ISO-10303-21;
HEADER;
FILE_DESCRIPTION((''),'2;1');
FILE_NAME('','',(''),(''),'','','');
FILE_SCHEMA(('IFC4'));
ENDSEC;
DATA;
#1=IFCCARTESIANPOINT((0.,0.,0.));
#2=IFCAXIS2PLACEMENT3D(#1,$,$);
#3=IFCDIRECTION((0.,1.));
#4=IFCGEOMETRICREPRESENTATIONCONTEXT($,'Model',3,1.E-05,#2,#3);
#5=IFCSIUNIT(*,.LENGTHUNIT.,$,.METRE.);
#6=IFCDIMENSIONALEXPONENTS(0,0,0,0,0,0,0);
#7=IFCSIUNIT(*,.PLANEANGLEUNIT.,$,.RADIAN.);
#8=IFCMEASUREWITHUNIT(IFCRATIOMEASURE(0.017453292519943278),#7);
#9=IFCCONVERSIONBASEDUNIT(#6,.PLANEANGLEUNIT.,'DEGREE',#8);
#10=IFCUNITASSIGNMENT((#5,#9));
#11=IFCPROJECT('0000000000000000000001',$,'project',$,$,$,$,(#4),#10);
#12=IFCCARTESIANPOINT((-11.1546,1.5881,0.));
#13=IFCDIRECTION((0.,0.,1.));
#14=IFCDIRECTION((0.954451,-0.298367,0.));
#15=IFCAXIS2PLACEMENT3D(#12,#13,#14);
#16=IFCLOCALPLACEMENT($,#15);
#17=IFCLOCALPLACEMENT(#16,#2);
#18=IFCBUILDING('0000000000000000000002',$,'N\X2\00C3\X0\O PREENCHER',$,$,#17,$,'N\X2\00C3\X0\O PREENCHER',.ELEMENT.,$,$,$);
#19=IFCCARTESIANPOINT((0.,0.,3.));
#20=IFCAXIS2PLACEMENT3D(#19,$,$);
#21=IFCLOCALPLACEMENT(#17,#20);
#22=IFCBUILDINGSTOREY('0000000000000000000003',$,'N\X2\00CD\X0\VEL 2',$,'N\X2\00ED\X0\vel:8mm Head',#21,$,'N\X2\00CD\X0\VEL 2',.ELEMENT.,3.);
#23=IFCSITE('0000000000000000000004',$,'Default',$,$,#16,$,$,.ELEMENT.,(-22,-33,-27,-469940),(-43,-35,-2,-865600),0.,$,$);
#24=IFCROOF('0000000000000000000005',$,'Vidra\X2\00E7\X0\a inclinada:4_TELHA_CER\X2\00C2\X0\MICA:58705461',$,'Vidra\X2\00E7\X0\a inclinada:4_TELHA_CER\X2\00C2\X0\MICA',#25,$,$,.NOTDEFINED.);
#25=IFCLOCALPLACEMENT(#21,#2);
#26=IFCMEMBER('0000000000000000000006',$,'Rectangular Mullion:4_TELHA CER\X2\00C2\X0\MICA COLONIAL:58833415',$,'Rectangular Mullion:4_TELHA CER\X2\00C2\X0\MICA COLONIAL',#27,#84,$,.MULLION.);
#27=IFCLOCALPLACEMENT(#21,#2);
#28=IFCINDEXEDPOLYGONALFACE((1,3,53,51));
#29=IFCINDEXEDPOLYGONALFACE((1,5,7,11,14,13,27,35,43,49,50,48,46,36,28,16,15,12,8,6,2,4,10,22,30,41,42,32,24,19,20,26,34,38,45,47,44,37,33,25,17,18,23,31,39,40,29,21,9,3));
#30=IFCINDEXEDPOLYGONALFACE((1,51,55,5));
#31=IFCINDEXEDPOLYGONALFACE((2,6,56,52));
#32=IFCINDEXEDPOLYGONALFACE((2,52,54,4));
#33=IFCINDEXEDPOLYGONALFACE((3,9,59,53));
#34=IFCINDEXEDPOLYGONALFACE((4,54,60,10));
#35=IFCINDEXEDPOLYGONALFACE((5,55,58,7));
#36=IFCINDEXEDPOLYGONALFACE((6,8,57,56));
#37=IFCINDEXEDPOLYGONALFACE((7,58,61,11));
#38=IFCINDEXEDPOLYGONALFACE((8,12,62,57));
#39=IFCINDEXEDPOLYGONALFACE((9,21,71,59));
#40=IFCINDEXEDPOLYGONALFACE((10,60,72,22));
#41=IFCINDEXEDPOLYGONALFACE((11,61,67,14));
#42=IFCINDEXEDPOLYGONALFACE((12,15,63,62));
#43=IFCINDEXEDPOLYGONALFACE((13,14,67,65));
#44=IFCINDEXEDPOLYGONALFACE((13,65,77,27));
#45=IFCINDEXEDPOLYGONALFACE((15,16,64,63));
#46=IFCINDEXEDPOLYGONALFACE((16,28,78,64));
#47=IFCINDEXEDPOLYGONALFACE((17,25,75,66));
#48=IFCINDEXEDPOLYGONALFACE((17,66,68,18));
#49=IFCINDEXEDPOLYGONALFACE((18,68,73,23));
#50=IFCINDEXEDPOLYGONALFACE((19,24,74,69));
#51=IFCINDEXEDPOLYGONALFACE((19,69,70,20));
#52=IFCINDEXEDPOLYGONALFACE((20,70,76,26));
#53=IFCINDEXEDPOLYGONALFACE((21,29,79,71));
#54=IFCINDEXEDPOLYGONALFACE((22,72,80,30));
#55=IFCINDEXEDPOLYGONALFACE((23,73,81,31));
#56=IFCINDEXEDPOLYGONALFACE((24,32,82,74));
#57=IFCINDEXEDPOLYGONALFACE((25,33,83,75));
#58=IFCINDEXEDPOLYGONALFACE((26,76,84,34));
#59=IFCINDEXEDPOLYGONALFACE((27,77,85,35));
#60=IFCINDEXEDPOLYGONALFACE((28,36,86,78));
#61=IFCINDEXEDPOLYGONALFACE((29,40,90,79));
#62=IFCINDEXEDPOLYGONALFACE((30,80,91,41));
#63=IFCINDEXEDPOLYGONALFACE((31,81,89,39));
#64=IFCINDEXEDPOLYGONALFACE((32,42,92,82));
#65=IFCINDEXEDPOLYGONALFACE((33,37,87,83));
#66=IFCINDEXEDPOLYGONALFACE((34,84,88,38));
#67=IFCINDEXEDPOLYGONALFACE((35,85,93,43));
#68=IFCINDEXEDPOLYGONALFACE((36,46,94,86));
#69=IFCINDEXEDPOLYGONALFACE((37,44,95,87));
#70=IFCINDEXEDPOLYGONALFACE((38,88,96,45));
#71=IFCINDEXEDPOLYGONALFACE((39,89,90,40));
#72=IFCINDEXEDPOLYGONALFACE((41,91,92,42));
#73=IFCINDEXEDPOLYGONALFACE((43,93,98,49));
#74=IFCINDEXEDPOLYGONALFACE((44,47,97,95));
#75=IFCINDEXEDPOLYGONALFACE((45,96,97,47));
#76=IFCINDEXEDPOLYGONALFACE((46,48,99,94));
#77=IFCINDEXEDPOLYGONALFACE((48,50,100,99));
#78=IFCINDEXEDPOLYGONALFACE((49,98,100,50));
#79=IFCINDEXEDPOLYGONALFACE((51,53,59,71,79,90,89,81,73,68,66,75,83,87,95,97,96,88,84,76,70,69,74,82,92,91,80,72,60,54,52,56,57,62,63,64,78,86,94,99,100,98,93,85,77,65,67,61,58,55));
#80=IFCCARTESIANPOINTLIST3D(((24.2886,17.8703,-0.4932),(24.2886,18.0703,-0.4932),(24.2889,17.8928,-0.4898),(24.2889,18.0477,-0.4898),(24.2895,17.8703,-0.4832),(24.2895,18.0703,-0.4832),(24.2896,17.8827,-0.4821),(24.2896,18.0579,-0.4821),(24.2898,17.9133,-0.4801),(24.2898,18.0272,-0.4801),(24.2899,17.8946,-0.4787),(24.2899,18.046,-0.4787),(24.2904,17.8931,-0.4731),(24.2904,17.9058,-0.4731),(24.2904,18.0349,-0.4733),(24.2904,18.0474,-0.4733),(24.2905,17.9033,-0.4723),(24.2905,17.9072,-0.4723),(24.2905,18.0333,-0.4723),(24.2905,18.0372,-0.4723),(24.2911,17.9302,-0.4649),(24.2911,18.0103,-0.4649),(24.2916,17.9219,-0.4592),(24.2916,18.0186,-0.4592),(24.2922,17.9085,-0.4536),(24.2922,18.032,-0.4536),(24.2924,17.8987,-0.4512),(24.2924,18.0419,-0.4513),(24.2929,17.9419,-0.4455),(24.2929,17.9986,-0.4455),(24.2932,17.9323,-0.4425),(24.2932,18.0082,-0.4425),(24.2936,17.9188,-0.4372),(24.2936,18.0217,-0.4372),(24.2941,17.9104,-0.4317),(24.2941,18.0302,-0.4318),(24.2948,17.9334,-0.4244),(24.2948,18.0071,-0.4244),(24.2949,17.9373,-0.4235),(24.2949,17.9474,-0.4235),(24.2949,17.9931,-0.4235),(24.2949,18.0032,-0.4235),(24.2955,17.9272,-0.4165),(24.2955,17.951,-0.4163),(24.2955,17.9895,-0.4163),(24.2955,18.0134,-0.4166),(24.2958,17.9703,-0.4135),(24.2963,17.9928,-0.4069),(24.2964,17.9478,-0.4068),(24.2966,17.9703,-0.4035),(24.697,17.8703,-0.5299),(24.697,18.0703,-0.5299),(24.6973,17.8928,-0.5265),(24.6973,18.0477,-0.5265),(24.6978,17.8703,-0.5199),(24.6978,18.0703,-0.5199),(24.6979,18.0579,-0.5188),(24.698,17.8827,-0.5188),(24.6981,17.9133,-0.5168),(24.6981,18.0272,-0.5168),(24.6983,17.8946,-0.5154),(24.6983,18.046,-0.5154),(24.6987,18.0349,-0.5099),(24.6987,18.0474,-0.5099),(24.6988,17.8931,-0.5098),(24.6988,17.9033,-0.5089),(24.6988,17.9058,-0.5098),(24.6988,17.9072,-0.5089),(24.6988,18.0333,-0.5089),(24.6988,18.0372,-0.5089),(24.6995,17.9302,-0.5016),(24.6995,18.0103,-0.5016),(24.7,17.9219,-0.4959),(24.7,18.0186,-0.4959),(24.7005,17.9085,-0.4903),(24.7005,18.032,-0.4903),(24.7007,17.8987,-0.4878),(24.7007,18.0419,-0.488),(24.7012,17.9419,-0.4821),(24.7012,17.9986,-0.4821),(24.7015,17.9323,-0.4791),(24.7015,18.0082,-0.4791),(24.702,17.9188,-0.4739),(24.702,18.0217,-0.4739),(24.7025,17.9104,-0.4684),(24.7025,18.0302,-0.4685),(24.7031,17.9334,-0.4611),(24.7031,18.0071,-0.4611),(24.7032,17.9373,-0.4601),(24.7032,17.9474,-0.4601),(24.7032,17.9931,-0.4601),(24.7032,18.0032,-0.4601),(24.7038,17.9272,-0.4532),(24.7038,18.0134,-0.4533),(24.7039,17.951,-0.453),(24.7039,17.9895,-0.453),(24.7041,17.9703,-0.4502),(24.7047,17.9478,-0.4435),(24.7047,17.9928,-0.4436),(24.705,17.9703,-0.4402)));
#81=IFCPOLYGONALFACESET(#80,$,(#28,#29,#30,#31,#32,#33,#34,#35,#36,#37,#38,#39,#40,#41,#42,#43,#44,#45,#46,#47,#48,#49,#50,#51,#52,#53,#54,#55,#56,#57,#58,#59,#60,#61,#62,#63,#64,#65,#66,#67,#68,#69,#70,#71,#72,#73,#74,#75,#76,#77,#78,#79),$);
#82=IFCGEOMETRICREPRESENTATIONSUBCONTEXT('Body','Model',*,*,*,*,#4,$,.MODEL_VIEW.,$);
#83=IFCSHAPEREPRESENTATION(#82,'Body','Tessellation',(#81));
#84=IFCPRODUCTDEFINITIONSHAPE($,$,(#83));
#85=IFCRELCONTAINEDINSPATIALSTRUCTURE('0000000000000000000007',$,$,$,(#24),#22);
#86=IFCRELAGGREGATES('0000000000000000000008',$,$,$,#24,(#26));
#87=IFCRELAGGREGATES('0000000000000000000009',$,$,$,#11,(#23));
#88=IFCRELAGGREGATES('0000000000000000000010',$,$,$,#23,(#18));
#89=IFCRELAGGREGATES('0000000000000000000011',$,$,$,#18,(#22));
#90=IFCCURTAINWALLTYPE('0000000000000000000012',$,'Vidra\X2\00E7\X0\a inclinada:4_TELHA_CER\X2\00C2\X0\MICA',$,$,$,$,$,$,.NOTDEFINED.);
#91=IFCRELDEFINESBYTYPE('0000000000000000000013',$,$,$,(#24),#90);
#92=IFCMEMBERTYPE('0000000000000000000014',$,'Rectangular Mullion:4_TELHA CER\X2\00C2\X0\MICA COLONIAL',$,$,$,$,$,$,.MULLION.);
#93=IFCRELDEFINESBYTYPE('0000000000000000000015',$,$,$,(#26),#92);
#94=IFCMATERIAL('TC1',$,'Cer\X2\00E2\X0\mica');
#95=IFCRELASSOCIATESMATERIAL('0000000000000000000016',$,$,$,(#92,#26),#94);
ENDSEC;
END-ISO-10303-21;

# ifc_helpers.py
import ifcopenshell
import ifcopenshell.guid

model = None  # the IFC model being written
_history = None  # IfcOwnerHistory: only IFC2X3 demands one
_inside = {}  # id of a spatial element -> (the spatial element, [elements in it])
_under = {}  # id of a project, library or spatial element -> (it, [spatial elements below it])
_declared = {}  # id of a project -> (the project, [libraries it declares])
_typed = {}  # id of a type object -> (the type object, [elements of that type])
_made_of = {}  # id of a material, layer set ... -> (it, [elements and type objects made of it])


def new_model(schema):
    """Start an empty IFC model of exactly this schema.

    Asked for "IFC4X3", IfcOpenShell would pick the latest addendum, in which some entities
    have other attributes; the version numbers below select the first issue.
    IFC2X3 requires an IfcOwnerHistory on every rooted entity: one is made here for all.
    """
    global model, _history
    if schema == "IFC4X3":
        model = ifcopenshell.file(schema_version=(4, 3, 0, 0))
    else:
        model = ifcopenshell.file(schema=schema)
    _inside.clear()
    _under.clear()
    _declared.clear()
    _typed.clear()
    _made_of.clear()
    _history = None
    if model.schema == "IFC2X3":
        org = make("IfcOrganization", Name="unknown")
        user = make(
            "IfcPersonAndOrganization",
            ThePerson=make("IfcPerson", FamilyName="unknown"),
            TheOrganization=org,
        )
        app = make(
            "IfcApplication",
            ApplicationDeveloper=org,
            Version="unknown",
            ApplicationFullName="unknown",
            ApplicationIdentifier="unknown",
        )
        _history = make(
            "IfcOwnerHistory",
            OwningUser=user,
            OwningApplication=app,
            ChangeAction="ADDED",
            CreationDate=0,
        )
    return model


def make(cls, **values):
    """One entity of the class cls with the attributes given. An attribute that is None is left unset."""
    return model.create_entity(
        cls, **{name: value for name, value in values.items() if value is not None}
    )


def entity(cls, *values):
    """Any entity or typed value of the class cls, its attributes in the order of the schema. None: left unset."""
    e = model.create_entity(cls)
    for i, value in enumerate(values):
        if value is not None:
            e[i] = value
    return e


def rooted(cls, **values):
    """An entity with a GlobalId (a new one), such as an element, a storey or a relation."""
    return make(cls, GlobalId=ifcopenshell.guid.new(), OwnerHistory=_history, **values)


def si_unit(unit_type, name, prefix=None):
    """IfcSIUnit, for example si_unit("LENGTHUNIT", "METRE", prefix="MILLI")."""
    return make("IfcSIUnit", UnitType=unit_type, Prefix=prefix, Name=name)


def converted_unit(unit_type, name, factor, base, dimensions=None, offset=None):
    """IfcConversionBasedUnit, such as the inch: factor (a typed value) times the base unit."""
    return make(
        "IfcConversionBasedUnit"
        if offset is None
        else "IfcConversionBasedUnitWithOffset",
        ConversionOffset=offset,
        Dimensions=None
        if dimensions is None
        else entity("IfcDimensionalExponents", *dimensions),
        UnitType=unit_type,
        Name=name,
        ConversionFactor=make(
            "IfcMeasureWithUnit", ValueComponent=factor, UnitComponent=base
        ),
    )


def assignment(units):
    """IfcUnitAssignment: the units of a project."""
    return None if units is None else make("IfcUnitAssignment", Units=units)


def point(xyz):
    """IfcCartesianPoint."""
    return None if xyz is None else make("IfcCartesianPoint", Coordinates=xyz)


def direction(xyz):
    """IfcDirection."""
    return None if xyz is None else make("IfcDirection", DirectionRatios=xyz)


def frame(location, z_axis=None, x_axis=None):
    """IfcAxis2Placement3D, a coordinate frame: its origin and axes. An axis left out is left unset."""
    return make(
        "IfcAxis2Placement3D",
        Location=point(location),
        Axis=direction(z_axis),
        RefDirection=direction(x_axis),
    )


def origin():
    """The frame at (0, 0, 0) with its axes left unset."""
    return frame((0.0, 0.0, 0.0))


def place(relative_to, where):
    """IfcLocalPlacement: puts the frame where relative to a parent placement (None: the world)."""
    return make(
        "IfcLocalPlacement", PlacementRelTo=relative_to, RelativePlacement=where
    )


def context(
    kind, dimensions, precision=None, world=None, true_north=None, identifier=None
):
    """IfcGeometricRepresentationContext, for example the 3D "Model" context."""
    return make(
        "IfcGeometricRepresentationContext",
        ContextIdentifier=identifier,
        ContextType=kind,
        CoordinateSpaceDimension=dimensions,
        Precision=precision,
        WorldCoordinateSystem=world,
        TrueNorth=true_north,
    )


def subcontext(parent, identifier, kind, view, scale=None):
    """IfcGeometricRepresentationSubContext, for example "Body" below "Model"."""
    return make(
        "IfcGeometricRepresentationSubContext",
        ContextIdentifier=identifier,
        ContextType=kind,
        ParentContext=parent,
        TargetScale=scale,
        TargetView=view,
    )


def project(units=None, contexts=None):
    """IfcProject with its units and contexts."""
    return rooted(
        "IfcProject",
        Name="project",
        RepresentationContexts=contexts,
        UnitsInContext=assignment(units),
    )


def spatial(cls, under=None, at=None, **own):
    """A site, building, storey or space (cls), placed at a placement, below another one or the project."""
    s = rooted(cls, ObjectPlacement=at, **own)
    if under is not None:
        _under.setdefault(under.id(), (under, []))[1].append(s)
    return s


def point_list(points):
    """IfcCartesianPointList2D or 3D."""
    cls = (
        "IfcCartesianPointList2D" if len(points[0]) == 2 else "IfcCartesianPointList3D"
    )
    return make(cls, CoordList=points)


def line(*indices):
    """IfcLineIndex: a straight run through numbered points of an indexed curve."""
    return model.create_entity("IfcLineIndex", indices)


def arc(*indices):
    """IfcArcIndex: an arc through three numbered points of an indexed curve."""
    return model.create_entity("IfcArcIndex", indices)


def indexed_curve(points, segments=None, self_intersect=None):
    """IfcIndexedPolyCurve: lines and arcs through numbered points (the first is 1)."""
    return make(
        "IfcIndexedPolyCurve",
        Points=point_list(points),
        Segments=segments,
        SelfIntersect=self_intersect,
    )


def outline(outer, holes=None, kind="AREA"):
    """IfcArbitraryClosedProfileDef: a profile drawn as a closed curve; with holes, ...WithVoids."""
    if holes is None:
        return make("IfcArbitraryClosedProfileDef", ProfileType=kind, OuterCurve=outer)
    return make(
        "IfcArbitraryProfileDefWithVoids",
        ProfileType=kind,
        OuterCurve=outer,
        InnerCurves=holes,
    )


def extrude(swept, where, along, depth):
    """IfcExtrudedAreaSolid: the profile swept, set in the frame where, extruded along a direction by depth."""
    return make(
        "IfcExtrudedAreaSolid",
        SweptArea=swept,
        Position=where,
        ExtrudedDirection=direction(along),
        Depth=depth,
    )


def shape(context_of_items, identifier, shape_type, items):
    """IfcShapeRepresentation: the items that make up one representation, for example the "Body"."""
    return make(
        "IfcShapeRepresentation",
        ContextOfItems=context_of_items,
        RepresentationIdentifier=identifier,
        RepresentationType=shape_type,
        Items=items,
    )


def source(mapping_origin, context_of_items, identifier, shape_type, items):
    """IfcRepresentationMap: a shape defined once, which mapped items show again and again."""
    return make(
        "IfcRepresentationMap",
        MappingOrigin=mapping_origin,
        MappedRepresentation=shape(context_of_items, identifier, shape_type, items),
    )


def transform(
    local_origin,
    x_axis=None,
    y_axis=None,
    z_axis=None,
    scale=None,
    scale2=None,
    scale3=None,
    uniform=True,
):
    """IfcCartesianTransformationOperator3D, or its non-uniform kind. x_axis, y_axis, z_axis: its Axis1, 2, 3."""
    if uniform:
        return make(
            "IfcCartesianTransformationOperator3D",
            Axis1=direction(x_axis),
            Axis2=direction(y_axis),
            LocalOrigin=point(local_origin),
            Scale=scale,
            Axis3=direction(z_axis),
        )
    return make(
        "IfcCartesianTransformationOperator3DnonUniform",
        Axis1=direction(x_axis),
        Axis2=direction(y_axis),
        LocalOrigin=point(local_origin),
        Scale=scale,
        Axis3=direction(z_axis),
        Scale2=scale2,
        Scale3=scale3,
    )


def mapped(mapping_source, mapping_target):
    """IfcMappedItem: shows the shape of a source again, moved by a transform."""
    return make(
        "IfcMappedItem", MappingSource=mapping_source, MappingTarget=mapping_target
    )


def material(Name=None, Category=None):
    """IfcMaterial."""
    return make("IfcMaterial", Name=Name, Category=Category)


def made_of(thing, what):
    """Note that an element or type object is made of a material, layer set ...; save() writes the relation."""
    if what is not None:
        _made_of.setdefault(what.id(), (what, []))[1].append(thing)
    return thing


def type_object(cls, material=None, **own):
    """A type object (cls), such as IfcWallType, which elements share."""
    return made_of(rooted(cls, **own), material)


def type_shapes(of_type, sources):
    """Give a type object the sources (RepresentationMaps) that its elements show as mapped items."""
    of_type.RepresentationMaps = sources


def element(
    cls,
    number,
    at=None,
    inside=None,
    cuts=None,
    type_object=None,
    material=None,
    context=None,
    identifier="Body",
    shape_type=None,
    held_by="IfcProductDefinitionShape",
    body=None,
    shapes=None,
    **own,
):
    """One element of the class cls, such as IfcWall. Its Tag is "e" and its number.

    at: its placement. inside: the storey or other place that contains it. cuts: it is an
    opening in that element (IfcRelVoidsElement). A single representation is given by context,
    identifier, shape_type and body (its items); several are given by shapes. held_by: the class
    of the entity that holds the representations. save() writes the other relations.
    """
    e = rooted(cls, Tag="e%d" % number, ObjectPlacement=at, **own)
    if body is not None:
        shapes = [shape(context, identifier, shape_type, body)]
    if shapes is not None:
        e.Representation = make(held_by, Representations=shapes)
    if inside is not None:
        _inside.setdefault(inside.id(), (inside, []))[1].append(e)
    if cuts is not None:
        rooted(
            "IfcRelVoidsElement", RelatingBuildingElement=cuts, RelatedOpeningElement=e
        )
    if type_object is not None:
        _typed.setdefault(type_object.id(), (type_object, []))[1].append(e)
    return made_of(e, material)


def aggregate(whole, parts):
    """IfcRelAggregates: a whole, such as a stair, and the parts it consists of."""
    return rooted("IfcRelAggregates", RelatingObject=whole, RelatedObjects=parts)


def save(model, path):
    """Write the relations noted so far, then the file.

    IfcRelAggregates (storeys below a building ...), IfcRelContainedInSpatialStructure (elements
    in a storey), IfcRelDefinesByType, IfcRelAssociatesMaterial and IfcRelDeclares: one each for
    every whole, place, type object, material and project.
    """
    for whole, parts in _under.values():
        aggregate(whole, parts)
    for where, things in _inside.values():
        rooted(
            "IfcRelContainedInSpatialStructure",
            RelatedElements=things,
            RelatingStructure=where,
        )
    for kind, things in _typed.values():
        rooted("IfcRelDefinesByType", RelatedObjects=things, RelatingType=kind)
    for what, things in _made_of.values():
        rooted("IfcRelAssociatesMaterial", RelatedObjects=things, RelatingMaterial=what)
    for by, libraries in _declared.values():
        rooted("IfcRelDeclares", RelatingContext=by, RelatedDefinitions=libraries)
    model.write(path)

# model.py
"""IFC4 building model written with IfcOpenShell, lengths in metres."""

from ifc_helpers import new_model, entity, si_unit, converted_unit, direction, frame, origin, place, context, subcontext, project, spatial, line, arc, indexed_curve, outline, extrude, source, transform, mapped, material, type_object, type_shapes, element, aggregate, save


model = new_model("IFC4")

# Units and contexts
model_context = context("Model", 3, precision=1e-05, world=origin(), true_north=direction((0.0, 1.0)))
body_context = subcontext(model_context, "Body", "Model", "MODEL_VIEW")
ifc_project = project(units=[si_unit("LENGTHUNIT", "METRE"), converted_unit("PLANEANGLEUNIT", "DEGREE", entity("IfcRatioMeasure", 0.017453292519943278), si_unit("PLANEANGLEUNIT", "RADIAN"), dimensions=[0, 0, 0, 0, 0, 0, 0])], contexts=[model_context])

# Site, building, storey
site_placement = place(None, frame((-11.1546, 1.5881, 0.0), z_axis=(0.0, 0.0, 1.0), x_axis=(0.954451, -0.298367, 0.0)))
site = spatial("IfcSite", under=ifc_project, at=site_placement, Name="Default", CompositionType="ELEMENT", RefLatitude=(-22, -33, -27, -469940), RefLongitude=(-43, -35, -2, -865600), RefElevation=0.0)
building_placement = place(site_placement, origin())
building = spatial("IfcBuilding", under=site, at=building_placement, Name="NÃO PREENCHER", LongName="NÃO PREENCHER", CompositionType="ELEMENT")
storey_placement = place(building_placement, frame((0.0, 0.0, 3.0)))
storey = spatial("IfcBuildingStorey", under=building, at=storey_placement, Name="NÍVEL 2", ObjectType="Nível:8mm Head", LongName="NÍVEL 2", CompositionType="ELEMENT", Elevation=3.0)

# Roof, member
curtain_wall_type = type_object("IfcCurtainWallType", Name="Vidraça inclinada:4_TELHA_CERÂMICA", PredefinedType="NOTDEFINED")
roof_placement = place(storey_placement, frame((0.0, 0.0, -3.0)))
roof = element("IfcRoof", 1, at=roof_placement, inside=storey, type_object=curtain_wall_type, Name="Vidraça inclinada:4_TELHA_CERÂMICA:58705461", ObjectType="Vidraça inclinada:4_TELHA_CERÂMICA", PredefinedType="NOTDEFINED")
ifc_material = material(Name="TC1", Category="Cerâmica")
member_type = type_object("IfcMemberType", Name="Rectangular Mullion:4_TELHA CERÂMICA COLONIAL", PredefinedType="MULLION", material=ifc_material)
shared_shape = source(origin(), body_context, "Body", "SweptSolid", [
    extrude(outline(indexed_curve([(-0.029, -0.1), (-0.019, -0.1), (-0.0164, -0.0815), (-0.0089, -0.0645), (-0.0089, -0.0771), (0.061, 0.0), (-0.009, 0.0771), (-0.009, 0.0646), (-0.0165, 0.0816), (-0.019, 0.1), (-0.029, 0.1), (-0.0089, 0.0479), (0.041, 0.0229), (0.041, 0.0329), (0.0131, 0.0425), (-0.008, 0.0631), (-0.008, 0.067), (0.051, 0.0), (-0.008, -0.067), (-0.008, -0.0631), (0.0131, -0.0425), (0.041, -0.0329), (0.041, -0.0229), (-0.0089, -0.0479)], segments=[line(1, 2), arc(2, 3, 4), line(4, 5), arc(5, 6, 7), line(7, 8), arc(8, 9, 10), line(10, 11), arc(11, 12, 13), line(13, 14), arc(14, 15, 16), line(16, 17), arc(17, 18, 19), line(19, 20), arc(20, 21, 22), line(22, 23), arc(23, 24, 1)], self_intersect=False)), frame((0.0, -0.029, -0.41), z_axis=(0.0, 0.0, 1.0), x_axis=(0.0, -1.0, 0.0)), (0.0, 0.0, 1.0), 0.41),
])
type_shapes(member_type, [shared_shape])
member_1_placement = place(roof_placement, frame((24.2886, 17.9703, 2.5068), z_axis=(-0.99599, 0.0, 0.089469), x_axis=(0.0, 1.0, 0.0)))
member_1 = element("IfcMember", 2, at=member_1_placement, type_object=member_type, material=ifc_material, Name="Rectangular Mullion:4_TELHA CERÂMICA COLONIAL:58833415", ObjectType="Rectangular Mullion:4_TELHA CERÂMICA COLONIAL", PredefinedType="MULLION", context=body_context, shape_type="MappedRepresentation", body=[
    mapped(shared_shape, transform((0.0, 0.0, 0.0), scale=1.0)),
])
aggregate(roof, [member_1])

save(model, "model.ifc")
